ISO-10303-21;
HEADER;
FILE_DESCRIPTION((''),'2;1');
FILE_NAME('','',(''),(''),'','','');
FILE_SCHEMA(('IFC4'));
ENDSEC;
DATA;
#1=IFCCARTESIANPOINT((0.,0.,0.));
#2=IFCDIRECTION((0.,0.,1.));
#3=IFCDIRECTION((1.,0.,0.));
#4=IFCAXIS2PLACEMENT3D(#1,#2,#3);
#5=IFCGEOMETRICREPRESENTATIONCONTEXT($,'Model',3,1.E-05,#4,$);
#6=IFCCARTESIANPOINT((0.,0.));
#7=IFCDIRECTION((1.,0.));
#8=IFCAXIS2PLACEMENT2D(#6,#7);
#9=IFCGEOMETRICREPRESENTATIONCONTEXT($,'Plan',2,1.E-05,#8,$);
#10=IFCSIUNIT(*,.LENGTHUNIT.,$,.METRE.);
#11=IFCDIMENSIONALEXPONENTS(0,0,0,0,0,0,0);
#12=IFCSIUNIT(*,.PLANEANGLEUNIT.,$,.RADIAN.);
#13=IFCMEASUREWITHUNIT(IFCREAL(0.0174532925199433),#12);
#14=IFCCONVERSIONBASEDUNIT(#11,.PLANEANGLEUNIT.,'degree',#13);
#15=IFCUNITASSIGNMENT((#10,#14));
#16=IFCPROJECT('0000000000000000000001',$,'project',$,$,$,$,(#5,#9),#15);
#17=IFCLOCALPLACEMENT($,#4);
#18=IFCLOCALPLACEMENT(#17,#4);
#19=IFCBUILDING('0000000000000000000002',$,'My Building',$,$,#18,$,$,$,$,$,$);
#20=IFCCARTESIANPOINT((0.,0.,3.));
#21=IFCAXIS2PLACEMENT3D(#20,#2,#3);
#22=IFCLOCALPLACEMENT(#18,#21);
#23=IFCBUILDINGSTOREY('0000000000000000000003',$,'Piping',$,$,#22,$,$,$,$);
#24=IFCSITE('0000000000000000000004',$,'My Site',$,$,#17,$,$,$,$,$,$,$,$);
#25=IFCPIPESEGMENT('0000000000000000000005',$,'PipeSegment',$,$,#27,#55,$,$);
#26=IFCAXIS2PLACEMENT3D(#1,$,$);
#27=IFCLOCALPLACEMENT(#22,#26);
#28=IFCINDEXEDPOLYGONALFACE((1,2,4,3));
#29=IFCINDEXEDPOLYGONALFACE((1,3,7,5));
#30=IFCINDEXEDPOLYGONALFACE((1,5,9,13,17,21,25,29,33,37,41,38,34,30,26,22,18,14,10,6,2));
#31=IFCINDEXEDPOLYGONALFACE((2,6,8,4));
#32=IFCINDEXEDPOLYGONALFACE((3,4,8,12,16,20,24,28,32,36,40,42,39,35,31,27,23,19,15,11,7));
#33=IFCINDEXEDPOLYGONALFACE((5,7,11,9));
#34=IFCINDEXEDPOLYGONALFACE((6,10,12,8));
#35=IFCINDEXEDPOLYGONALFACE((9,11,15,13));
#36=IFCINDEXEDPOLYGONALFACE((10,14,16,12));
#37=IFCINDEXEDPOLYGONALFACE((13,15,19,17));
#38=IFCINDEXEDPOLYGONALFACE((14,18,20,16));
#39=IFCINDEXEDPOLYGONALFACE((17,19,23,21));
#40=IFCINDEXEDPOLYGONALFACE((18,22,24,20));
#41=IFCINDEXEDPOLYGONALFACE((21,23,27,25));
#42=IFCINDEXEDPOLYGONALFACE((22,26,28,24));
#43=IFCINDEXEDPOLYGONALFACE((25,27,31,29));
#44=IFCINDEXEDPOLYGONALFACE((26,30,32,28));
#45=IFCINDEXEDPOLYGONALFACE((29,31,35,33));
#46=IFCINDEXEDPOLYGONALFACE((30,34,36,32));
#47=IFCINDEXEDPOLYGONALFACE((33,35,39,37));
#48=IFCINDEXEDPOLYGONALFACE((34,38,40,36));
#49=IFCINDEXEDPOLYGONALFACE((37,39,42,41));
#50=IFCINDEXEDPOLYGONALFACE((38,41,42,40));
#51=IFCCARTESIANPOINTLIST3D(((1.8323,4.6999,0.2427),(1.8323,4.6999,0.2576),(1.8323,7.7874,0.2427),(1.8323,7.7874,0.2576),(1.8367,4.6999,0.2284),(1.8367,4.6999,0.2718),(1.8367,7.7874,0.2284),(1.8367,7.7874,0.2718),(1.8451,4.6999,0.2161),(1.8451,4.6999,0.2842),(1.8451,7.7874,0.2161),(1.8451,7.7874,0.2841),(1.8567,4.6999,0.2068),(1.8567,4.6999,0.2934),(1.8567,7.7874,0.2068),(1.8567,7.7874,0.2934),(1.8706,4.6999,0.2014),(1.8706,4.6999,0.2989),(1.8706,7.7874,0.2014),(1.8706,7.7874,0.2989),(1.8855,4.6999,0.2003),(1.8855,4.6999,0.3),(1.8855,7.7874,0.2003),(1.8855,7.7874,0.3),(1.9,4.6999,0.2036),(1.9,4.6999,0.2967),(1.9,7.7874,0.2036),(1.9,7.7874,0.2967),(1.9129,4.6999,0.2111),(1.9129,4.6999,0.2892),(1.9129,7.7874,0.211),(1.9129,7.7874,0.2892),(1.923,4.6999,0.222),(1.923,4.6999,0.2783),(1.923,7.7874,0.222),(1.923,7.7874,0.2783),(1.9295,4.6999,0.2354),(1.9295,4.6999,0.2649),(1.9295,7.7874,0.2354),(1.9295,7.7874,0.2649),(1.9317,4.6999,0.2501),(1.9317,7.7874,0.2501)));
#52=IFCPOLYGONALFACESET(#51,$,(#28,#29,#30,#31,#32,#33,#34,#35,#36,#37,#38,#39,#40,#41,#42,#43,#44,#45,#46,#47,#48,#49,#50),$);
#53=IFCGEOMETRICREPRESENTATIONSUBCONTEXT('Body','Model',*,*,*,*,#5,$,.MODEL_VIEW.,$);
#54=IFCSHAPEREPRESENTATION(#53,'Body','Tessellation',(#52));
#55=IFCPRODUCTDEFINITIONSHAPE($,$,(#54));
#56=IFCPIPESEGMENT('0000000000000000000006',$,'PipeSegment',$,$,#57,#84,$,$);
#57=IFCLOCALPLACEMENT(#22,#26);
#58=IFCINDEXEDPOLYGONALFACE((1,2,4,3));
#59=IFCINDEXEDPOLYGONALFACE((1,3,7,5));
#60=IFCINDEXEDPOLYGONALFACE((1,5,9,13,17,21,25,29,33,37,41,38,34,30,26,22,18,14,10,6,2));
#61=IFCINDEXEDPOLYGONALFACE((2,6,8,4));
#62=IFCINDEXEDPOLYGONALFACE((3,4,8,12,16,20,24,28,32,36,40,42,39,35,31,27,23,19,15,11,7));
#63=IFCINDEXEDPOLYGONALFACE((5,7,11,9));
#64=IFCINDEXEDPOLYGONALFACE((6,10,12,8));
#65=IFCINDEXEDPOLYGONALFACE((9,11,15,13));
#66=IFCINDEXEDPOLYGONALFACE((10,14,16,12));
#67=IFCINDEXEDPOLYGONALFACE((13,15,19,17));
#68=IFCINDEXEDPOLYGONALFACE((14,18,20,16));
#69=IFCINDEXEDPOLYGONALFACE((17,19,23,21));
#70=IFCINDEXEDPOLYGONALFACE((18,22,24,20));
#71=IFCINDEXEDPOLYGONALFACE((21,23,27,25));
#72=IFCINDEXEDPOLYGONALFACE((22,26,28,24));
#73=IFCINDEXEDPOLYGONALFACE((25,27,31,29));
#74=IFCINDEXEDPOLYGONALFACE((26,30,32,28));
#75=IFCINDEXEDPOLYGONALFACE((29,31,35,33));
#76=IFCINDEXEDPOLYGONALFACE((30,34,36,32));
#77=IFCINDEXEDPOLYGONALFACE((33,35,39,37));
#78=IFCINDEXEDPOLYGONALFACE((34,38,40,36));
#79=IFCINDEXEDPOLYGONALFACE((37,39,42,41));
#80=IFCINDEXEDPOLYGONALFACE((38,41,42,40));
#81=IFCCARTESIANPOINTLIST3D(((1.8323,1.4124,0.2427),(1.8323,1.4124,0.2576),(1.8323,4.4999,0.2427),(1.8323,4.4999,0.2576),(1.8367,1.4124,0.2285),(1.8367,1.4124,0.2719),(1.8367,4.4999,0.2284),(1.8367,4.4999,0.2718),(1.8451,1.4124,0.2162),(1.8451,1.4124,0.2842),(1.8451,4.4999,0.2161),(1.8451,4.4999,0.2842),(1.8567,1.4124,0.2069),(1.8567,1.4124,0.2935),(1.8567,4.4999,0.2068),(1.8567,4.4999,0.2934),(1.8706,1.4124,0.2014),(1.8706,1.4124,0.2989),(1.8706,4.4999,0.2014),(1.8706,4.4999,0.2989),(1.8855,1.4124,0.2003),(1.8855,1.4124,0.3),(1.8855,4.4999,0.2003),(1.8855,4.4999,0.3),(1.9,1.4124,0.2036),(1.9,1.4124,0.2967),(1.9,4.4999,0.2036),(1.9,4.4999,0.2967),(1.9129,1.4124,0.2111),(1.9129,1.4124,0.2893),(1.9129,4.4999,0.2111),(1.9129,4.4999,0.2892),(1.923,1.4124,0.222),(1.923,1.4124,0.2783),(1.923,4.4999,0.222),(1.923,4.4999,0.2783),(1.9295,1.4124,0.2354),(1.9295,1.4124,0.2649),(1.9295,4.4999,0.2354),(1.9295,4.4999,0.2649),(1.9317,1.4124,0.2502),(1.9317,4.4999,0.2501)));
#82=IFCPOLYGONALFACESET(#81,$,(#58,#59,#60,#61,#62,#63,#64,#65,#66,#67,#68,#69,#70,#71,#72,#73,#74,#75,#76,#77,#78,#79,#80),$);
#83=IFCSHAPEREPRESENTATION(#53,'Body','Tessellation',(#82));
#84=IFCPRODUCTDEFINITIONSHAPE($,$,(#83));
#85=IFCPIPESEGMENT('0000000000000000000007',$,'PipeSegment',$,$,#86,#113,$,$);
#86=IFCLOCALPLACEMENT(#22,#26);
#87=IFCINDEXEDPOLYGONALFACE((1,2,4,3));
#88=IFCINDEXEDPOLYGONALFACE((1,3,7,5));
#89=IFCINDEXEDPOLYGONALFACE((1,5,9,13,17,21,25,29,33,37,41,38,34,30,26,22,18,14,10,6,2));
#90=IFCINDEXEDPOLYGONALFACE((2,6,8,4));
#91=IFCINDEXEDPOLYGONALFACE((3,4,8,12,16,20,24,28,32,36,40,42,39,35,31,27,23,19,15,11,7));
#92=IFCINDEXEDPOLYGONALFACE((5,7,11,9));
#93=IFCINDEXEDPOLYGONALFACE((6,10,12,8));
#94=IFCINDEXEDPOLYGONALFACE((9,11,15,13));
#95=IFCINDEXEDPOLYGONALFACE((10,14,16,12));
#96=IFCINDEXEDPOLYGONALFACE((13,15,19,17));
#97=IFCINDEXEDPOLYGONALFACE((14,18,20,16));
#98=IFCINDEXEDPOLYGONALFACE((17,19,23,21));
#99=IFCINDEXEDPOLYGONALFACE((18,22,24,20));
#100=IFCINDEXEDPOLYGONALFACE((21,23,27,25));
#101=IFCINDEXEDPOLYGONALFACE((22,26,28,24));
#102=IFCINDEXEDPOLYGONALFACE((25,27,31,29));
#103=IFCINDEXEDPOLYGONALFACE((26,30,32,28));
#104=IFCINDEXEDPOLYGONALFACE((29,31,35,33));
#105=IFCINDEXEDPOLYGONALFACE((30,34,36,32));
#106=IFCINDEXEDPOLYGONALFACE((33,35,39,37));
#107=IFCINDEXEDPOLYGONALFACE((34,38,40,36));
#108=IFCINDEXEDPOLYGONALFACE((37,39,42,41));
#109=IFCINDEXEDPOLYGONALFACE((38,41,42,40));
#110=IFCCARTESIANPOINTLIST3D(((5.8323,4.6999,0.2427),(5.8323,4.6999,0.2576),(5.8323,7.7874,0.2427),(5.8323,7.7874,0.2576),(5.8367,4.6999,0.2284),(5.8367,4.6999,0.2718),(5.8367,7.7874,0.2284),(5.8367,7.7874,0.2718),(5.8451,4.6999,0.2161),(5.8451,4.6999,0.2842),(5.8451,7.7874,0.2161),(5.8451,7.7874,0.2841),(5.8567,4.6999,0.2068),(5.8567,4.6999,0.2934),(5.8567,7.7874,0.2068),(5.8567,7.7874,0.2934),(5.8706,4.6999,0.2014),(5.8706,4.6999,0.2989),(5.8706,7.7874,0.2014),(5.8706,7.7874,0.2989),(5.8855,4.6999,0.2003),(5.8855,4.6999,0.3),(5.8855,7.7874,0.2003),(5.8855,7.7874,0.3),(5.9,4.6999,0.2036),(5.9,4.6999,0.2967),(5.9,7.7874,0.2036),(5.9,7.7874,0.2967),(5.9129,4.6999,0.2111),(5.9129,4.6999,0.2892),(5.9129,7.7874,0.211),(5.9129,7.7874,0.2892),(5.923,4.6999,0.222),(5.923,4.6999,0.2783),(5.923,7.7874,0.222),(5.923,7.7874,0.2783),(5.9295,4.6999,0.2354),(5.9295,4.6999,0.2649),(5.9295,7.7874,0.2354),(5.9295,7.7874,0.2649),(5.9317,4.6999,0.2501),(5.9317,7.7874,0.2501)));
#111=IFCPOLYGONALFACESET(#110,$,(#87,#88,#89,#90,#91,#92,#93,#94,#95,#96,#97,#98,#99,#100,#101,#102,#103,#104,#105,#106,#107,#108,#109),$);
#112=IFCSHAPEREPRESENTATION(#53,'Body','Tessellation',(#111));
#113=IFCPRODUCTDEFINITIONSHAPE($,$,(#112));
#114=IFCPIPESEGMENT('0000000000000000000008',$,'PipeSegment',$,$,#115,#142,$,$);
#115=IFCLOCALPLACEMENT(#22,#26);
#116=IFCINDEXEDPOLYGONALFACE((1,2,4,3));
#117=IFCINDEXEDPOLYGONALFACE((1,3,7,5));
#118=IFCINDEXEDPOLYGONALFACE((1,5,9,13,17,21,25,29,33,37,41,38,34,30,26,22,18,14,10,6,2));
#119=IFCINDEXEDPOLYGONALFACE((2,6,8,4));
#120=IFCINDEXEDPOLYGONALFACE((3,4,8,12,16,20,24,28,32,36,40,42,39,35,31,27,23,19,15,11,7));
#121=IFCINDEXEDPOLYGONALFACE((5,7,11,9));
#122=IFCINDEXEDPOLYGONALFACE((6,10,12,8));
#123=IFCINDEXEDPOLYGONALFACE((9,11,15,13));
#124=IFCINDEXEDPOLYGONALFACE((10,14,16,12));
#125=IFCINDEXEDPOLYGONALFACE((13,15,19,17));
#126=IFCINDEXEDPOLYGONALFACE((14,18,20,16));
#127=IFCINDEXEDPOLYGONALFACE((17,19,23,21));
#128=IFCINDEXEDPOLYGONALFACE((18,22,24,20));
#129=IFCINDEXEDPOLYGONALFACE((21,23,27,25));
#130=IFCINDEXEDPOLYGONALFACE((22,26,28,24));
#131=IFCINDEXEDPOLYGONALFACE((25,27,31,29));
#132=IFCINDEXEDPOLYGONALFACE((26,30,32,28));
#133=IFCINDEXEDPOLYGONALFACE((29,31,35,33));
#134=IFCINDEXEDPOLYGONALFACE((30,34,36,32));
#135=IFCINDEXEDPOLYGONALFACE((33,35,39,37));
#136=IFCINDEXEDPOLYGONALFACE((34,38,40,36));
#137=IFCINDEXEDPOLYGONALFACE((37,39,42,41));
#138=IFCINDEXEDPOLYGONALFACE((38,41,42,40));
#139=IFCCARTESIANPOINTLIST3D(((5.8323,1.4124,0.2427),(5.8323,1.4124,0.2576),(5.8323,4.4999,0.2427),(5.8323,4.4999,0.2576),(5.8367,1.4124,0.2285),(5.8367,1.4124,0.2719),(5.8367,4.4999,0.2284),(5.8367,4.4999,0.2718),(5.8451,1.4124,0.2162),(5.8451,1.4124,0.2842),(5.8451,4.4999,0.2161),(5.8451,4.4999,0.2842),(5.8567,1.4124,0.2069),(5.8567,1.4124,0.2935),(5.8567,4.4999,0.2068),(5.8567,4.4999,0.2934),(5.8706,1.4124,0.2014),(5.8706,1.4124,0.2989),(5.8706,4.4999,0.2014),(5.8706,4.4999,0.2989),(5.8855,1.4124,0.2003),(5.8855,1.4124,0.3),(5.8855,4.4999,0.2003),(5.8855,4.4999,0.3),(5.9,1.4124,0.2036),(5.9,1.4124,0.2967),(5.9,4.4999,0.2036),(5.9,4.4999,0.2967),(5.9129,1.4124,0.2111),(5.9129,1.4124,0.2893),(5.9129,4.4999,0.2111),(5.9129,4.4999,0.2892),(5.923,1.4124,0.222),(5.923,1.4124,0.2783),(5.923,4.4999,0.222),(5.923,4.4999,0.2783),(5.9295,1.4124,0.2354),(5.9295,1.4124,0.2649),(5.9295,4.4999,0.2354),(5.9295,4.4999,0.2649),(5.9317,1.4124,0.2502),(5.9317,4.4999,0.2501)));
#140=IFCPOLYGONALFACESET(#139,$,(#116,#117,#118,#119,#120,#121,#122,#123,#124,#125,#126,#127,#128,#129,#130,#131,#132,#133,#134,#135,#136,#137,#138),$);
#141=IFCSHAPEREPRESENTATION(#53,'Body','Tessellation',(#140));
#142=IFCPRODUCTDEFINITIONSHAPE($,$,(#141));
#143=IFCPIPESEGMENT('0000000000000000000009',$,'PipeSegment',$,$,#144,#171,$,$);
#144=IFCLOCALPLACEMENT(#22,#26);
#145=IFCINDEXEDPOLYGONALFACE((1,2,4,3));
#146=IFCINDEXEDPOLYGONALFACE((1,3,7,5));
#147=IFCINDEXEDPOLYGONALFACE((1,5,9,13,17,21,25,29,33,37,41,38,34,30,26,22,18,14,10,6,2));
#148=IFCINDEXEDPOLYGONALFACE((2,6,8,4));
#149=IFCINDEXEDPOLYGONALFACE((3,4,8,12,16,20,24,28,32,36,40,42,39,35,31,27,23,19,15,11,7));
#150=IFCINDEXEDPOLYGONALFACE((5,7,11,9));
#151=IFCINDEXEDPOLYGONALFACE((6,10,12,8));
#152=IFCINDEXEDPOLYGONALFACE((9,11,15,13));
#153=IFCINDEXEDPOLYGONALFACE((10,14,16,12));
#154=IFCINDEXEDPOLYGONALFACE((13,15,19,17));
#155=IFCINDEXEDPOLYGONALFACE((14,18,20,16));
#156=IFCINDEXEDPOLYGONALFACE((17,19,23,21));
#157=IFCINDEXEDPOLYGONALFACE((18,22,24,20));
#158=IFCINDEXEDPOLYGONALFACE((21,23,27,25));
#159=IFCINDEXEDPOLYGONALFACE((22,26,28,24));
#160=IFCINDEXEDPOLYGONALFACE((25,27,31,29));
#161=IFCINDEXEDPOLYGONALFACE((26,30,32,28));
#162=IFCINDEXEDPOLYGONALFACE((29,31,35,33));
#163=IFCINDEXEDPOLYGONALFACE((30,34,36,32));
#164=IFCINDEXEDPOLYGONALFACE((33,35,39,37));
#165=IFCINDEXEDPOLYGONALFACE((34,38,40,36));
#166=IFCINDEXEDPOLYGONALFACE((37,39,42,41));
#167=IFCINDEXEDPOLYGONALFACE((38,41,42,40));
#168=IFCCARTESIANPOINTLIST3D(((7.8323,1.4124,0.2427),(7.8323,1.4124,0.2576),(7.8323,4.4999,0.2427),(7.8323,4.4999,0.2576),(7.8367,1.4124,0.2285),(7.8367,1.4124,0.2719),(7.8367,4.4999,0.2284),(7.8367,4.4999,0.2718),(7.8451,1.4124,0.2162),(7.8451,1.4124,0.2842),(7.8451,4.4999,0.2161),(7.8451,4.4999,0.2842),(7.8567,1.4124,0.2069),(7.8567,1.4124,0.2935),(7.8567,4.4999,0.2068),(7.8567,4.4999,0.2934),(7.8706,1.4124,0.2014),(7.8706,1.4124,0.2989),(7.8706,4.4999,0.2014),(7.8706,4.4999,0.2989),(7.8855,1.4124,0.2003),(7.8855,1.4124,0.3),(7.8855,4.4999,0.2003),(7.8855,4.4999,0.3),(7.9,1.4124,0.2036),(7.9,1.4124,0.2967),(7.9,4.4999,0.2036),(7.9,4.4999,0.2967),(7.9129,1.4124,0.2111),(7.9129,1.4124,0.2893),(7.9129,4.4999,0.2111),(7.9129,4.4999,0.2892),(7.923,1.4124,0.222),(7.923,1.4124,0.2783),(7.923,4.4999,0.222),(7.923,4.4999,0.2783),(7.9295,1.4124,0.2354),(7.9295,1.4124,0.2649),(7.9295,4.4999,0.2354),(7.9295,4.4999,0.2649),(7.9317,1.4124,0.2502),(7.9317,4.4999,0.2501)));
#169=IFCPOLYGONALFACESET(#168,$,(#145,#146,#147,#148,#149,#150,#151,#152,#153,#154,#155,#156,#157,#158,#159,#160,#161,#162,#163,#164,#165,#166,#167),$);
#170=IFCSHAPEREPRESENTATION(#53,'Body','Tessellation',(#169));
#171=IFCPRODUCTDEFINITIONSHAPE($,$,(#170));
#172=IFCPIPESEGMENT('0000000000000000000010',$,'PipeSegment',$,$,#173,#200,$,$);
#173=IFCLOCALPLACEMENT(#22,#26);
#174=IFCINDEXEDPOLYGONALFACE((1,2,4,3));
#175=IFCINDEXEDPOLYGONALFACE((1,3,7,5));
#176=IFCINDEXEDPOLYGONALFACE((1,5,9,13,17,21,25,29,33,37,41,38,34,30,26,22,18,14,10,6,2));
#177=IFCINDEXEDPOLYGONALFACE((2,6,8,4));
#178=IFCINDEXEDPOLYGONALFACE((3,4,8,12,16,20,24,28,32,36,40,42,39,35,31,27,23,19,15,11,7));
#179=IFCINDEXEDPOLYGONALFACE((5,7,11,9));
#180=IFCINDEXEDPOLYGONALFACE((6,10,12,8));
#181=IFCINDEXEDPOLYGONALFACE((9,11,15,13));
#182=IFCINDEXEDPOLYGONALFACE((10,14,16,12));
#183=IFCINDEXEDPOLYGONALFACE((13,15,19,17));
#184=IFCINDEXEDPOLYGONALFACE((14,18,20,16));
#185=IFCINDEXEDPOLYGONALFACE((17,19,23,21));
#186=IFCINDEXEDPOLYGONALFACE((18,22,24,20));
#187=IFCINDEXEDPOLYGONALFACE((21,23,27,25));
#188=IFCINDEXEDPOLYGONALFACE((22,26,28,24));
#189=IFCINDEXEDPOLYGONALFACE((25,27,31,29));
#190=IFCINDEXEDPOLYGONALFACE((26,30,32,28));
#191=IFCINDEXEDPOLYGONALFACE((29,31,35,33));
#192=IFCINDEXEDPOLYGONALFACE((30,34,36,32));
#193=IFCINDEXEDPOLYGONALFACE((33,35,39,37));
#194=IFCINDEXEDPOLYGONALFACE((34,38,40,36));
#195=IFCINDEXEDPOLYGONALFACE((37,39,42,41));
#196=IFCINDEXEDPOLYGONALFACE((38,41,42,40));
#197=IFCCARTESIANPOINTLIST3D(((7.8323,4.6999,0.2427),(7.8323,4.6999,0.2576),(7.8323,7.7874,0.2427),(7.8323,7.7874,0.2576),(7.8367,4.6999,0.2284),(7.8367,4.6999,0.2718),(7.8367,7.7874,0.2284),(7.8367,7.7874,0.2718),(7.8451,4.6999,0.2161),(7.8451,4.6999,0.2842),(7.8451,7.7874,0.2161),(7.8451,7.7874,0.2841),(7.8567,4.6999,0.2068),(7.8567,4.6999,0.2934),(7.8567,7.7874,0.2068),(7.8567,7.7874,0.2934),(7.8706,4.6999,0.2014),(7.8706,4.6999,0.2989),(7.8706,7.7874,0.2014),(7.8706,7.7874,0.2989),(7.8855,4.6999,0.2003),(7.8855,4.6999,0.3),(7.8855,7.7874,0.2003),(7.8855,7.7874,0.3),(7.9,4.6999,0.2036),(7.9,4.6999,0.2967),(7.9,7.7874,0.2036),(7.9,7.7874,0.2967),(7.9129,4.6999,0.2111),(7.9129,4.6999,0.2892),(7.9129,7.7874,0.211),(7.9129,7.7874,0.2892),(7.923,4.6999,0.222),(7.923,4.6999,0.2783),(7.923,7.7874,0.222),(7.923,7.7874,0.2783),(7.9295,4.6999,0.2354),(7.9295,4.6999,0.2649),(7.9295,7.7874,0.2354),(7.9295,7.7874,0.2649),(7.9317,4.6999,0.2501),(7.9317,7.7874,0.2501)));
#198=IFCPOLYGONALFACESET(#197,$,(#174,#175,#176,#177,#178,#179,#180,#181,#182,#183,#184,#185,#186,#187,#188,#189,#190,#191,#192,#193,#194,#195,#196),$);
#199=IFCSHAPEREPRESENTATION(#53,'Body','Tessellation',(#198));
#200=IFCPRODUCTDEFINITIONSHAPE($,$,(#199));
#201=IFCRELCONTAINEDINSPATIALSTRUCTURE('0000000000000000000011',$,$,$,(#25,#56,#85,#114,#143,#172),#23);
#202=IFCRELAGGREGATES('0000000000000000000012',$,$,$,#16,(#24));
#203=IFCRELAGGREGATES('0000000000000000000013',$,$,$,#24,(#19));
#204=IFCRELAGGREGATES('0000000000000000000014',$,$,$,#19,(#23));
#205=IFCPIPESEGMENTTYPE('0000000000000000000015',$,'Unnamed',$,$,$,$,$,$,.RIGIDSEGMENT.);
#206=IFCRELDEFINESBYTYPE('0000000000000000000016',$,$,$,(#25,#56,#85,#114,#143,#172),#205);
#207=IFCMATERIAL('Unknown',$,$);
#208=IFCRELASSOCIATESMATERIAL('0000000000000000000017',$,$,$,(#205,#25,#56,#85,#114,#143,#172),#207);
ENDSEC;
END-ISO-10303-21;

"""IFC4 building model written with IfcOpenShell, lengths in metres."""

from ifc_helpers import new_model, entity, si_unit, converted_unit, frame, origin_with_axes, origin_2d_with_axis, place, context, subcontext, project, spatial, circle, extrude, material, material_profile, profile_set, profile_usage, type_object, element, save


model = new_model("IFC4")

# Units and contexts
model_context = context("Model", 3, precision=1e-05, world=origin_with_axes())
plan_context = context("Plan", 2, precision=1e-05, world=origin_2d_with_axis())
body_context = subcontext(model_context, "Body", "Model", "MODEL_VIEW")
ifc_project = project(units=[si_unit("LENGTHUNIT", "METRE"), converted_unit("PLANEANGLEUNIT", "degree", entity("IfcReal", 0.0174532925199433), si_unit("PLANEANGLEUNIT", "RADIAN"), dimensions=[0, 0, 0, 0, 0, 0, 0])], contexts=[model_context, plan_context])

# Site, building, storey
site_placement = place(None, origin_with_axes())
site = spatial("IfcSite", under=ifc_project, at=site_placement, Name="My Site")
building_placement = place(site_placement, origin_with_axes())
building = spatial("IfcBuilding", under=site, at=building_placement, Name="My Building")
storey_placement = place(building_placement, frame((0.0, 0.0, 3.0), z_axis=(0.0, 0.0, 1.0), x_axis=(1.0, 0.0, 0.0)))
storey = spatial("IfcBuildingStorey", under=building, at=storey_placement, Name="Piping")

# Pipe segments
ifc_material = material(Name="Unknown")
ifc_material_profile_1 = material_profile(ifc_material, circle(Radius=0.05))
ifc_profile_set_1 = profile_set([ifc_material_profile_1])
ifc_profile_usage_1 = profile_usage(ifc_profile_set_1, cardinal=5)
pipe_segment_type = type_object("IfcPipeSegmentType", Name="Unnamed", PredefinedType="RIGIDSEGMENT", material=ifc_profile_set_1)
pipe_segment_1_placement = place(storey_placement, frame((1.8817, 4.6999, 0.2501), z_axis=(0.0, 1.0, -0.000008), x_axis=(1.0, 0.0, 0.0)))
element("IfcPipeSegment", 1, at=pipe_segment_1_placement, inside=storey, type_object=pipe_segment_type, material=ifc_profile_usage_1, Name="PipeSegment", context=body_context, shape_type="SweptSolid", body=[
    extrude(circle(Radius=0.05), origin_with_axes(), (0.0, 0.0, 1.0), 3.0875),
])
ifc_profile_usage_2 = profile_usage(ifc_profile_set_1, cardinal=5)
pipe_segment_2_placement = place(storey_placement, frame((1.8817, 4.4999, 0.2501), z_axis=(0.0, -1.0, 0.000008), x_axis=(1.0, 0.0, 0.0)))
element("IfcPipeSegment", 2, at=pipe_segment_2_placement, inside=storey, type_object=pipe_segment_type, material=ifc_profile_usage_2, Name="PipeSegment", context=body_context, shape_type="SweptSolid", body=[
    extrude(circle(Radius=0.05), origin_with_axes(), (0.0, 0.0, 1.0), 3.0875),
])
ifc_profile_usage_3 = profile_usage(ifc_profile_set_1, cardinal=5)
pipe_segment_3_placement = place(storey_placement, frame((5.8817, 4.6999, 0.2501), z_axis=(0.0, 1.0, -0.000008), x_axis=(1.0, 0.0, 0.0)))
element("IfcPipeSegment", 3, at=pipe_segment_3_placement, inside=storey, type_object=pipe_segment_type, material=ifc_profile_usage_3, Name="PipeSegment", context=body_context, shape_type="SweptSolid", body=[
    extrude(circle(Radius=0.05), origin_with_axes(), (0.0, 0.0, 1.0), 3.0875),
])
ifc_profile_usage_4 = profile_usage(ifc_profile_set_1, cardinal=5)
pipe_segment_4_placement = place(storey_placement, frame((5.8817, 4.4999, 0.2501), z_axis=(0.0, -1.0, 0.000008), x_axis=(1.0, 0.0, 0.0)))
element("IfcPipeSegment", 4, at=pipe_segment_4_placement, inside=storey, type_object=pipe_segment_type, material=ifc_profile_usage_4, Name="PipeSegment", context=body_context, shape_type="SweptSolid", body=[
    extrude(circle(Radius=0.05), origin_with_axes(), (0.0, 0.0, 1.0), 3.0875),
])
ifc_profile_usage_5 = profile_usage(ifc_profile_set_1, cardinal=5)
pipe_segment_5_placement = place(storey_placement, frame((7.8817, 4.4999, 0.2501), z_axis=(0.0, -1.0, 0.000008), x_axis=(1.0, 0.0, 0.0)))
element("IfcPipeSegment", 5, at=pipe_segment_5_placement, inside=storey, type_object=pipe_segment_type, material=ifc_profile_usage_5, Name="PipeSegment", context=body_context, shape_type="SweptSolid", body=[
    extrude(circle(Radius=0.05), origin_with_axes(), (0.0, 0.0, 1.0), 3.0875),
])
ifc_profile_usage_6 = profile_usage(ifc_profile_set_1, cardinal=5)
pipe_segment_6_placement = place(storey_placement, frame((7.8817, 4.6999, 0.2501), z_axis=(0.0, 1.0, -0.000008), x_axis=(1.0, 0.0, 0.0)))
element("IfcPipeSegment", 6, at=pipe_segment_6_placement, inside=storey, type_object=pipe_segment_type, material=ifc_profile_usage_6, Name="PipeSegment", context=body_context, shape_type="SweptSolid", body=[
    extrude(circle(Radius=0.05), origin_with_axes(), (0.0, 0.0, 1.0), 3.0875),
])

save(model, "model.ifc")
